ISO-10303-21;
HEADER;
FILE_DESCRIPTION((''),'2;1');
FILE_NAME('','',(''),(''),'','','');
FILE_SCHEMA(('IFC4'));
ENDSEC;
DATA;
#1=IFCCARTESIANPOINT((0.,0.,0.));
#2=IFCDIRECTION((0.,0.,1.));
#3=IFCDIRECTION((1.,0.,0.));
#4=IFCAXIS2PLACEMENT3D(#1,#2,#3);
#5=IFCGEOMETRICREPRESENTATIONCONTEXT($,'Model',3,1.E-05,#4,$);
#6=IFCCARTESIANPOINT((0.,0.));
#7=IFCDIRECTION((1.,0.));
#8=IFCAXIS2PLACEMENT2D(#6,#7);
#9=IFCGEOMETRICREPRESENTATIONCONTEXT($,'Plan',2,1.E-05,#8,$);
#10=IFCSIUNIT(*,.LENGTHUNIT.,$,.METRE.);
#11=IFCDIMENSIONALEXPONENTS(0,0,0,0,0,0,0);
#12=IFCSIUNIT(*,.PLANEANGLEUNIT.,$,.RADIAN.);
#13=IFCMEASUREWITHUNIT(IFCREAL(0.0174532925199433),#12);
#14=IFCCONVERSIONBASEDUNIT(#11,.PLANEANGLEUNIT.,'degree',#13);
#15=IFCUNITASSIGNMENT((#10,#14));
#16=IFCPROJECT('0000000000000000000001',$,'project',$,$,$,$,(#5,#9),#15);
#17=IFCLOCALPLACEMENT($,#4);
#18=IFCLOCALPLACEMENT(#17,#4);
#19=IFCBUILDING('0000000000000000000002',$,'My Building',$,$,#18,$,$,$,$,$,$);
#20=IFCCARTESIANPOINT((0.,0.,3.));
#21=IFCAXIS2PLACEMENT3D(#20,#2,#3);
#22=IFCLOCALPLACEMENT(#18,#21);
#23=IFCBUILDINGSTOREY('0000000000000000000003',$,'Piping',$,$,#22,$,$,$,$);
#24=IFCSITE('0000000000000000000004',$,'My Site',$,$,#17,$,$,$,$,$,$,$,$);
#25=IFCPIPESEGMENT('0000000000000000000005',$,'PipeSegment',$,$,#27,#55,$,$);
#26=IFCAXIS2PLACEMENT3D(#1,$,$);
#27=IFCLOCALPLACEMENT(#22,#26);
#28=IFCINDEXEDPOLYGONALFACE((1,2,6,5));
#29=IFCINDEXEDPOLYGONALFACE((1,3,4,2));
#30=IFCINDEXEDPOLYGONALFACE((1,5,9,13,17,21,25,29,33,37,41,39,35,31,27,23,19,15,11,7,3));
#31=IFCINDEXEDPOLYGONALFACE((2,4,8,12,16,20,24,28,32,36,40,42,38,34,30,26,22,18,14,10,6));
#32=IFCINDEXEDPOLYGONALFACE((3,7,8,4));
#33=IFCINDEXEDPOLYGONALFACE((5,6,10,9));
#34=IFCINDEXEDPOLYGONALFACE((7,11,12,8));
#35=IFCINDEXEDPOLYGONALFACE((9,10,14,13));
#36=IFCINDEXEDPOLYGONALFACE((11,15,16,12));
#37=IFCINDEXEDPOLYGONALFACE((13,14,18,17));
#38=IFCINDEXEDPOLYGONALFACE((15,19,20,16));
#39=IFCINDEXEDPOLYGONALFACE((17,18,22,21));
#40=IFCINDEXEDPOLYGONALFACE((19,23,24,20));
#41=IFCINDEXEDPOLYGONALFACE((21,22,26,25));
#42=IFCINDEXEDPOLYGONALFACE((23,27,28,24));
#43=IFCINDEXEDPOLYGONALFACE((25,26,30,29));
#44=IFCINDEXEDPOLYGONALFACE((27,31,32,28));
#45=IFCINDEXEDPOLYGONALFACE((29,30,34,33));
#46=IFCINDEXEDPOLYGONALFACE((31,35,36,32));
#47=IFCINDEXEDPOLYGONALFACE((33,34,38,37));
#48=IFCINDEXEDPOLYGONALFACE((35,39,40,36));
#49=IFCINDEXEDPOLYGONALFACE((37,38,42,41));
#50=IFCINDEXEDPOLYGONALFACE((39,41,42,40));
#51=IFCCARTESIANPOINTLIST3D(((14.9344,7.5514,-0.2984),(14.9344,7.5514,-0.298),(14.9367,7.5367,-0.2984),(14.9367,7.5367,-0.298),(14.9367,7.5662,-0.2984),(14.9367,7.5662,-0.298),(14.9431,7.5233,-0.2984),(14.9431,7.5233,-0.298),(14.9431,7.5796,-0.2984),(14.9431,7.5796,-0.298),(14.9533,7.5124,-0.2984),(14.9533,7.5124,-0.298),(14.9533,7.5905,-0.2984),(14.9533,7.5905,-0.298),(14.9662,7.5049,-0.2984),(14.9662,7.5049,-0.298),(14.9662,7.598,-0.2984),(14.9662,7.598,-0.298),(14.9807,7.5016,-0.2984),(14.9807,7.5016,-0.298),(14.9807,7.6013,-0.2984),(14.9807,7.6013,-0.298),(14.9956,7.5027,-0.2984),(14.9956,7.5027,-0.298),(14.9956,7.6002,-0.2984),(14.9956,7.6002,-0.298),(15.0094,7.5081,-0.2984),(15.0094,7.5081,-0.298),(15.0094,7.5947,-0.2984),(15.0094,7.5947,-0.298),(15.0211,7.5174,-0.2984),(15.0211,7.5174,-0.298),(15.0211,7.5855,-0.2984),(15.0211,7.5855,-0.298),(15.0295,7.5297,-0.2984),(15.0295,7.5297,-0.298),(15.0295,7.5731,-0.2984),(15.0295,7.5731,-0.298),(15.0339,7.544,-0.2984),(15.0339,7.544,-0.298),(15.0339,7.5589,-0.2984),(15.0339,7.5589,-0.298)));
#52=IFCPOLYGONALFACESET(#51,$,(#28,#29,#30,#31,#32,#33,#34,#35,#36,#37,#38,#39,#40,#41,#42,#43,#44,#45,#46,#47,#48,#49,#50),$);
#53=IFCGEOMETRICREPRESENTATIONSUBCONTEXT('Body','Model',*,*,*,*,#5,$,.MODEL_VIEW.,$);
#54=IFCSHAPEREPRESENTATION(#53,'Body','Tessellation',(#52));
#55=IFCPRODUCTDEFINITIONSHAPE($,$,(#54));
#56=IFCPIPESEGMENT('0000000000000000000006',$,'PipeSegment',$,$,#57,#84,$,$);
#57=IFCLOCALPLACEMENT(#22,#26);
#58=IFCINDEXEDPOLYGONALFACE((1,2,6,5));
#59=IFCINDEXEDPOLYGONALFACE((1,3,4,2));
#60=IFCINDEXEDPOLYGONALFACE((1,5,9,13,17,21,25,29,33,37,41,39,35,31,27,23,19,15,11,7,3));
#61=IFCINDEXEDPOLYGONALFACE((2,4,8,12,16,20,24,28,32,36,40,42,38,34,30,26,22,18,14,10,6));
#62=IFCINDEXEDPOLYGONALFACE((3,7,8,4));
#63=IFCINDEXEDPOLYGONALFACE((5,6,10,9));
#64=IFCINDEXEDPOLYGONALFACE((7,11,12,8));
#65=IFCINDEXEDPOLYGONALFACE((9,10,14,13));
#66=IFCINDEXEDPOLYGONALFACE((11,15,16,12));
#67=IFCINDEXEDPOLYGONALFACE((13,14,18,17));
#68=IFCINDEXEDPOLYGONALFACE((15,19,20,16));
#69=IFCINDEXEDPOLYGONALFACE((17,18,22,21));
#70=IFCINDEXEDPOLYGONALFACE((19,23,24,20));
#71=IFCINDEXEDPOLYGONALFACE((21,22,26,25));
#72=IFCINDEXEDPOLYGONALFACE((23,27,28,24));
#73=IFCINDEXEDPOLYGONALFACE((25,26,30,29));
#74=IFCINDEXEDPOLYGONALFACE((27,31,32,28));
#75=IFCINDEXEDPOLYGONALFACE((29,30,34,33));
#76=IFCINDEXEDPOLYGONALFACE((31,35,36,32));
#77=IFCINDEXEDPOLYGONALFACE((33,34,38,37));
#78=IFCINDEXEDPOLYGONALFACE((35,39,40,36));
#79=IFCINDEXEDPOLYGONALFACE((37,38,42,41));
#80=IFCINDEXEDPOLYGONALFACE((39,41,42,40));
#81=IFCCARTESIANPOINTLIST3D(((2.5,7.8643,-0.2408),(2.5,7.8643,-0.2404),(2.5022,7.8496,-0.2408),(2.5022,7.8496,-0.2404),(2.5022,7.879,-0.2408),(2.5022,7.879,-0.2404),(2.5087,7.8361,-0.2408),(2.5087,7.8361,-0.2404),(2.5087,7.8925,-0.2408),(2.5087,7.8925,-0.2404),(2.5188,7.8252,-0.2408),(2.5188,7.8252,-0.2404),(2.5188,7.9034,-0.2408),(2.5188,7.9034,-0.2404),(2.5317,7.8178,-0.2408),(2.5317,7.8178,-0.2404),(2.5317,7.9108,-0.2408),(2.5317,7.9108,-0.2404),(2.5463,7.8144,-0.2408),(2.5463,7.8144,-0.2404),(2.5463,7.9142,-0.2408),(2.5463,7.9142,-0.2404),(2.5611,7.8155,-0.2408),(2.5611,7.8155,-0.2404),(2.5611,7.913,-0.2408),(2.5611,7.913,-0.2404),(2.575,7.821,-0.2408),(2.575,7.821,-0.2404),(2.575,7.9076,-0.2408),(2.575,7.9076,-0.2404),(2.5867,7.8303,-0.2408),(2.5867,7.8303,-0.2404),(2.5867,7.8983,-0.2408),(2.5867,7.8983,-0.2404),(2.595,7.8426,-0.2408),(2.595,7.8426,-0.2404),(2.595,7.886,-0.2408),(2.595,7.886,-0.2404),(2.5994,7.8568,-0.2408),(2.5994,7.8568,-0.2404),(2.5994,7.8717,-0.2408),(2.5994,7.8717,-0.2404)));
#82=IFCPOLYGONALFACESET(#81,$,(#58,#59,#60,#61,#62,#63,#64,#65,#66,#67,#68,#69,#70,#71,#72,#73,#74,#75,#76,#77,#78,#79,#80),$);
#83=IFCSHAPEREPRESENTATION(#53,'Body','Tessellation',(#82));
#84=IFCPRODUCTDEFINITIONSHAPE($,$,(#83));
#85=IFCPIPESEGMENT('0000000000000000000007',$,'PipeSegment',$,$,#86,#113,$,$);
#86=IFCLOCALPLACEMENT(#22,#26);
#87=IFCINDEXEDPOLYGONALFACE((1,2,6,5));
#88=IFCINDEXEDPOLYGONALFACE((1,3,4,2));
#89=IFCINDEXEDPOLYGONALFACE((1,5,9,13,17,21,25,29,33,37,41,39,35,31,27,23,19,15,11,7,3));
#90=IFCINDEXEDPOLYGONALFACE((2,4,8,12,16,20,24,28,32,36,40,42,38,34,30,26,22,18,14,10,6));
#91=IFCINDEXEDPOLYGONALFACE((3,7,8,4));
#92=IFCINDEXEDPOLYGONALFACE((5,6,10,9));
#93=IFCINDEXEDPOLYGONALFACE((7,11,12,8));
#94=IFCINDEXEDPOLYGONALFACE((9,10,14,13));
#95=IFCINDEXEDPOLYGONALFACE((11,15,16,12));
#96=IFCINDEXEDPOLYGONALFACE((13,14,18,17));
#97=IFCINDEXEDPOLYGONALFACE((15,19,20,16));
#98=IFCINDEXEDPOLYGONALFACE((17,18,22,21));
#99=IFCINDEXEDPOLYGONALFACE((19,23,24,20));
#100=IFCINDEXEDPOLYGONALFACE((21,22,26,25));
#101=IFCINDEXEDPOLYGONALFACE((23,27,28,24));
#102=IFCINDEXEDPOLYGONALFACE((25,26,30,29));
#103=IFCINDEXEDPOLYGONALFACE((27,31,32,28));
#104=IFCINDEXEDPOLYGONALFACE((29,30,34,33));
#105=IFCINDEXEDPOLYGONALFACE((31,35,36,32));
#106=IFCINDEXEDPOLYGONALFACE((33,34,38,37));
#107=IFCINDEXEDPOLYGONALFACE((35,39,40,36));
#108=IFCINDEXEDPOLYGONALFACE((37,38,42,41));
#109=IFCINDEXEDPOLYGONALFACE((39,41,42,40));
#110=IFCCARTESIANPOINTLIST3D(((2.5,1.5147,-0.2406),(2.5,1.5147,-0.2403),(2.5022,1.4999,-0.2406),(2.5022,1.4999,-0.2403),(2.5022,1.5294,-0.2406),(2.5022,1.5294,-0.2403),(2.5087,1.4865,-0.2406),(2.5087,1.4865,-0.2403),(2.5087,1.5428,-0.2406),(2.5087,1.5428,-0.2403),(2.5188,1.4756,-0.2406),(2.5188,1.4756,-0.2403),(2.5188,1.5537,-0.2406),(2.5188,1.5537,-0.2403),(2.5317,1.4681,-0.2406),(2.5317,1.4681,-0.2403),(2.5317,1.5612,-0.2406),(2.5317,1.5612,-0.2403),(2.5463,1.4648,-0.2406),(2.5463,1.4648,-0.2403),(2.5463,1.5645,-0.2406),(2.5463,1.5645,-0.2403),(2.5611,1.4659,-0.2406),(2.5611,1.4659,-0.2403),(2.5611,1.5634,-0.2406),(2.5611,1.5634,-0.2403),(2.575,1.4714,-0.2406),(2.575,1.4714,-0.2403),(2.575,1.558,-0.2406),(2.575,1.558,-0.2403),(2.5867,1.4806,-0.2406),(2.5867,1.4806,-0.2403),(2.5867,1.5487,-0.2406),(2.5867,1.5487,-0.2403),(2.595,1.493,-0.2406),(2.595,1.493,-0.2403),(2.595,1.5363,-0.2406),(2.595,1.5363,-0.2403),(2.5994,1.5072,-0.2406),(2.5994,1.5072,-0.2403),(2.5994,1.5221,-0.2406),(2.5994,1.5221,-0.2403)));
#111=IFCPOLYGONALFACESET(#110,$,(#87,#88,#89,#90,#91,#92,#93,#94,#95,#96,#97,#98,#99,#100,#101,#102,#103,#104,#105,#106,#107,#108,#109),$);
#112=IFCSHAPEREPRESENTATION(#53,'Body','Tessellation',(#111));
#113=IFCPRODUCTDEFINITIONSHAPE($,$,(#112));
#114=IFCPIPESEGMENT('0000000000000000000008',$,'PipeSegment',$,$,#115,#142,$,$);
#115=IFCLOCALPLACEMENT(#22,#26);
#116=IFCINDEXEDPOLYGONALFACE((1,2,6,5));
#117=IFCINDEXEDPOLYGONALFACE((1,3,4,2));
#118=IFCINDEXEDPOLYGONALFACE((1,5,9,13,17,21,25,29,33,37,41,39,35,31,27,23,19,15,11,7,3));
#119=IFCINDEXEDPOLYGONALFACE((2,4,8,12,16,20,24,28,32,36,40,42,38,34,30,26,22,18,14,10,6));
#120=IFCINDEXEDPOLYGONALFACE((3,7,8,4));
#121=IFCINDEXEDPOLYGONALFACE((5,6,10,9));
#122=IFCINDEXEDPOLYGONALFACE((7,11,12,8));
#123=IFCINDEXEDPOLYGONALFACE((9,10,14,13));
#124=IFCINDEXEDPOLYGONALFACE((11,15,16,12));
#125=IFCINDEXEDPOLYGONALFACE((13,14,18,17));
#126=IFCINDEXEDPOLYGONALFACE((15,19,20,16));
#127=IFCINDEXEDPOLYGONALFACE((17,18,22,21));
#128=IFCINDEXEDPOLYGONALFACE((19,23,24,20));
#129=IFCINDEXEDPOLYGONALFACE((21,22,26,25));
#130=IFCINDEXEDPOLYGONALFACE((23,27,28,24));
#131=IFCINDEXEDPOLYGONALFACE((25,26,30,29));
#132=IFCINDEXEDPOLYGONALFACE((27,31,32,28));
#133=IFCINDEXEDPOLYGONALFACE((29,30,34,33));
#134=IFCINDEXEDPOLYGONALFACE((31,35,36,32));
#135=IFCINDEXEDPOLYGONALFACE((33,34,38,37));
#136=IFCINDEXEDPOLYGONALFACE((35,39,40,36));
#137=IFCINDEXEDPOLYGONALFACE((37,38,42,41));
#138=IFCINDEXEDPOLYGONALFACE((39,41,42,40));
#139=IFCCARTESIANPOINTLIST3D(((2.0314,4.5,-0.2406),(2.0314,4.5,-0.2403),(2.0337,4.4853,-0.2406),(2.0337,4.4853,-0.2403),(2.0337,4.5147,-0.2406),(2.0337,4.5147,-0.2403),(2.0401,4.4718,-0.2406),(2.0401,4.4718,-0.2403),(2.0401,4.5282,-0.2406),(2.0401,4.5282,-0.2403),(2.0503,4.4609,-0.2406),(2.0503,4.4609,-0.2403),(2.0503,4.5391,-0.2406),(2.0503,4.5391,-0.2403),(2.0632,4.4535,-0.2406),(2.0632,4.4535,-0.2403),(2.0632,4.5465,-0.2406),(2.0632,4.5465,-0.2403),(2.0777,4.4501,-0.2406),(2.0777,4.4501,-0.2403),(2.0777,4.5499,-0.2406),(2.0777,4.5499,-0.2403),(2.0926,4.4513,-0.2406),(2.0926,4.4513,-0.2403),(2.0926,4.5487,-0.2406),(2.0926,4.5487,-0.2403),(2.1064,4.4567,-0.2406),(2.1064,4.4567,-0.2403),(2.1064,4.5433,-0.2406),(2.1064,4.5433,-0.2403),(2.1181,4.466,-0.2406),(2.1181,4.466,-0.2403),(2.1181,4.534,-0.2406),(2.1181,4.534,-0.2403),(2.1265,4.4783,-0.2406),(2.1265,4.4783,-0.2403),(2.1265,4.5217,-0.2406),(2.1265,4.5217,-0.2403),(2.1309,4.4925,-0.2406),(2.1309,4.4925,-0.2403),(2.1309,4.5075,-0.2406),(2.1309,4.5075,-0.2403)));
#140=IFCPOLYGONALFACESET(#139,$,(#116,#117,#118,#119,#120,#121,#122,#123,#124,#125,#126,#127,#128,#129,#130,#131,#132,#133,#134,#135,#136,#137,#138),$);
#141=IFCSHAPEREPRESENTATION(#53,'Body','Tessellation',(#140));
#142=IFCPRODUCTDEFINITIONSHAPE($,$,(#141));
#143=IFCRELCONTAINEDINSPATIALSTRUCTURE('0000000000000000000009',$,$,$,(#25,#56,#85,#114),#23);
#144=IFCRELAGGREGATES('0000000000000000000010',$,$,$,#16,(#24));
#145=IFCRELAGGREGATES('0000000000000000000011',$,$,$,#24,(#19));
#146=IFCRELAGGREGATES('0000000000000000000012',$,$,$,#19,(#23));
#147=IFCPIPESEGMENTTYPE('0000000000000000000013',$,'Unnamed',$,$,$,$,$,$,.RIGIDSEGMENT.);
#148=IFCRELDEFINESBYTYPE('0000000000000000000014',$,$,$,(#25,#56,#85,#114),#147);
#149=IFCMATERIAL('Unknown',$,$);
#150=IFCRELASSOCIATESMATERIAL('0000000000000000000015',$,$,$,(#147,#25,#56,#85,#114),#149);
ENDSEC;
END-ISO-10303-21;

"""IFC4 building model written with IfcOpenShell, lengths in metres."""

from ifc_helpers import new_model, entity, si_unit, converted_unit, frame, origin_with_axes, origin_2d_with_axis, place, context, subcontext, project, spatial, circle, extrude, material, material_profile, profile_set, profile_usage, type_object, element, save


model = new_model("IFC4")

# Units and contexts
model_context = context("Model", 3, precision=1e-05, world=origin_with_axes())
plan_context = context("Plan", 2, precision=1e-05, world=origin_2d_with_axis())
body_context = subcontext(model_context, "Body", "Model", "MODEL_VIEW")
ifc_project = project(units=[si_unit("LENGTHUNIT", "METRE"), converted_unit("PLANEANGLEUNIT", "degree", entity("IfcReal", 0.0174532925199433), si_unit("PLANEANGLEUNIT", "RADIAN"), dimensions=[0, 0, 0, 0, 0, 0, 0])], contexts=[model_context, plan_context])

# Site, building, storey
site_placement = place(None, origin_with_axes())
site = spatial("IfcSite", under=ifc_project, at=site_placement, Name="My Site")
building_placement = place(site_placement, origin_with_axes())
building = spatial("IfcBuilding", under=site, at=building_placement, Name="My Building")
storey_placement = place(building_placement, frame((0.0, 0.0, 3.0), z_axis=(0.0, 0.0, 1.0), x_axis=(1.0, 0.0, 0.0)))
storey = spatial("IfcBuildingStorey", under=building, at=storey_placement, Name="Piping")

# Pipe segments
ifc_material = material(Name="Unknown")
ifc_material_profile_1 = material_profile(ifc_material, circle(Radius=0.05))
ifc_profile_set_1 = profile_set([ifc_material_profile_1])
pipe_segment_type = type_object("IfcPipeSegmentType", Name="Unnamed", PredefinedType="RIGIDSEGMENT", material=ifc_profile_set_1)
ifc_profile_usage_1 = profile_usage(ifc_profile_set_1, cardinal=5)
pipe_segment_1_placement = place(storey_placement, frame((14.9844, 7.5514, -0.298), z_axis=(0.0, 0.0, -1.0), x_axis=(-1.0, 0.0, 0.0)))
element("IfcPipeSegment", 1, at=pipe_segment_1_placement, inside=storey, type_object=pipe_segment_type, material=ifc_profile_usage_1, Name="PipeSegment", context=body_context, shape_type="SweptSolid", body=[
    extrude(circle(Radius=0.05), origin_with_axes(), (0.0, 0.0, 1.0), 0.0004),
])
ifc_profile_usage_2 = profile_usage(ifc_profile_set_1, cardinal=5)
pipe_segment_2_placement = place(storey_placement, frame((2.55, 7.8643, -0.2404), z_axis=(0.0, 0.0, -1.0), x_axis=(-1.0, 0.0, 0.0)))
element("IfcPipeSegment", 2, at=pipe_segment_2_placement, inside=storey, type_object=pipe_segment_type, material=ifc_profile_usage_2, Name="PipeSegment", context=body_context, shape_type="SweptSolid", body=[
    extrude(circle(Radius=0.05), origin_with_axes(), (0.0, 0.0, 1.0), 0.0004),
])
ifc_profile_usage_3 = profile_usage(ifc_profile_set_1, cardinal=5)
pipe_segment_3_placement = place(storey_placement, frame((2.55, 1.5147, -0.2403), z_axis=(0.0, 0.0, -1.0), x_axis=(-1.0, 0.0, 0.0)))
element("IfcPipeSegment", 3, at=pipe_segment_3_placement, inside=storey, type_object=pipe_segment_type, material=ifc_profile_usage_3, Name="PipeSegment", context=body_context, shape_type="SweptSolid", body=[
    extrude(circle(Radius=0.05), origin_with_axes(), (0.0, 0.0, 1.0), 0.0004),
])
ifc_profile_usage_4 = profile_usage(ifc_profile_set_1, cardinal=5)
pipe_segment_4_placement = place(storey_placement, frame((2.0814, 4.5, -0.2403), z_axis=(0.0, 0.0, -1.0), x_axis=(-1.0, 0.0, 0.0)))
element("IfcPipeSegment", 4, at=pipe_segment_4_placement, inside=storey, type_object=pipe_segment_type, material=ifc_profile_usage_4, Name="PipeSegment", context=body_context, shape_type="SweptSolid", body=[
    extrude(circle(Radius=0.05), origin_with_axes(), (0.0, 0.0, 1.0), 0.0004),
])

save(model, "model.ifc")
